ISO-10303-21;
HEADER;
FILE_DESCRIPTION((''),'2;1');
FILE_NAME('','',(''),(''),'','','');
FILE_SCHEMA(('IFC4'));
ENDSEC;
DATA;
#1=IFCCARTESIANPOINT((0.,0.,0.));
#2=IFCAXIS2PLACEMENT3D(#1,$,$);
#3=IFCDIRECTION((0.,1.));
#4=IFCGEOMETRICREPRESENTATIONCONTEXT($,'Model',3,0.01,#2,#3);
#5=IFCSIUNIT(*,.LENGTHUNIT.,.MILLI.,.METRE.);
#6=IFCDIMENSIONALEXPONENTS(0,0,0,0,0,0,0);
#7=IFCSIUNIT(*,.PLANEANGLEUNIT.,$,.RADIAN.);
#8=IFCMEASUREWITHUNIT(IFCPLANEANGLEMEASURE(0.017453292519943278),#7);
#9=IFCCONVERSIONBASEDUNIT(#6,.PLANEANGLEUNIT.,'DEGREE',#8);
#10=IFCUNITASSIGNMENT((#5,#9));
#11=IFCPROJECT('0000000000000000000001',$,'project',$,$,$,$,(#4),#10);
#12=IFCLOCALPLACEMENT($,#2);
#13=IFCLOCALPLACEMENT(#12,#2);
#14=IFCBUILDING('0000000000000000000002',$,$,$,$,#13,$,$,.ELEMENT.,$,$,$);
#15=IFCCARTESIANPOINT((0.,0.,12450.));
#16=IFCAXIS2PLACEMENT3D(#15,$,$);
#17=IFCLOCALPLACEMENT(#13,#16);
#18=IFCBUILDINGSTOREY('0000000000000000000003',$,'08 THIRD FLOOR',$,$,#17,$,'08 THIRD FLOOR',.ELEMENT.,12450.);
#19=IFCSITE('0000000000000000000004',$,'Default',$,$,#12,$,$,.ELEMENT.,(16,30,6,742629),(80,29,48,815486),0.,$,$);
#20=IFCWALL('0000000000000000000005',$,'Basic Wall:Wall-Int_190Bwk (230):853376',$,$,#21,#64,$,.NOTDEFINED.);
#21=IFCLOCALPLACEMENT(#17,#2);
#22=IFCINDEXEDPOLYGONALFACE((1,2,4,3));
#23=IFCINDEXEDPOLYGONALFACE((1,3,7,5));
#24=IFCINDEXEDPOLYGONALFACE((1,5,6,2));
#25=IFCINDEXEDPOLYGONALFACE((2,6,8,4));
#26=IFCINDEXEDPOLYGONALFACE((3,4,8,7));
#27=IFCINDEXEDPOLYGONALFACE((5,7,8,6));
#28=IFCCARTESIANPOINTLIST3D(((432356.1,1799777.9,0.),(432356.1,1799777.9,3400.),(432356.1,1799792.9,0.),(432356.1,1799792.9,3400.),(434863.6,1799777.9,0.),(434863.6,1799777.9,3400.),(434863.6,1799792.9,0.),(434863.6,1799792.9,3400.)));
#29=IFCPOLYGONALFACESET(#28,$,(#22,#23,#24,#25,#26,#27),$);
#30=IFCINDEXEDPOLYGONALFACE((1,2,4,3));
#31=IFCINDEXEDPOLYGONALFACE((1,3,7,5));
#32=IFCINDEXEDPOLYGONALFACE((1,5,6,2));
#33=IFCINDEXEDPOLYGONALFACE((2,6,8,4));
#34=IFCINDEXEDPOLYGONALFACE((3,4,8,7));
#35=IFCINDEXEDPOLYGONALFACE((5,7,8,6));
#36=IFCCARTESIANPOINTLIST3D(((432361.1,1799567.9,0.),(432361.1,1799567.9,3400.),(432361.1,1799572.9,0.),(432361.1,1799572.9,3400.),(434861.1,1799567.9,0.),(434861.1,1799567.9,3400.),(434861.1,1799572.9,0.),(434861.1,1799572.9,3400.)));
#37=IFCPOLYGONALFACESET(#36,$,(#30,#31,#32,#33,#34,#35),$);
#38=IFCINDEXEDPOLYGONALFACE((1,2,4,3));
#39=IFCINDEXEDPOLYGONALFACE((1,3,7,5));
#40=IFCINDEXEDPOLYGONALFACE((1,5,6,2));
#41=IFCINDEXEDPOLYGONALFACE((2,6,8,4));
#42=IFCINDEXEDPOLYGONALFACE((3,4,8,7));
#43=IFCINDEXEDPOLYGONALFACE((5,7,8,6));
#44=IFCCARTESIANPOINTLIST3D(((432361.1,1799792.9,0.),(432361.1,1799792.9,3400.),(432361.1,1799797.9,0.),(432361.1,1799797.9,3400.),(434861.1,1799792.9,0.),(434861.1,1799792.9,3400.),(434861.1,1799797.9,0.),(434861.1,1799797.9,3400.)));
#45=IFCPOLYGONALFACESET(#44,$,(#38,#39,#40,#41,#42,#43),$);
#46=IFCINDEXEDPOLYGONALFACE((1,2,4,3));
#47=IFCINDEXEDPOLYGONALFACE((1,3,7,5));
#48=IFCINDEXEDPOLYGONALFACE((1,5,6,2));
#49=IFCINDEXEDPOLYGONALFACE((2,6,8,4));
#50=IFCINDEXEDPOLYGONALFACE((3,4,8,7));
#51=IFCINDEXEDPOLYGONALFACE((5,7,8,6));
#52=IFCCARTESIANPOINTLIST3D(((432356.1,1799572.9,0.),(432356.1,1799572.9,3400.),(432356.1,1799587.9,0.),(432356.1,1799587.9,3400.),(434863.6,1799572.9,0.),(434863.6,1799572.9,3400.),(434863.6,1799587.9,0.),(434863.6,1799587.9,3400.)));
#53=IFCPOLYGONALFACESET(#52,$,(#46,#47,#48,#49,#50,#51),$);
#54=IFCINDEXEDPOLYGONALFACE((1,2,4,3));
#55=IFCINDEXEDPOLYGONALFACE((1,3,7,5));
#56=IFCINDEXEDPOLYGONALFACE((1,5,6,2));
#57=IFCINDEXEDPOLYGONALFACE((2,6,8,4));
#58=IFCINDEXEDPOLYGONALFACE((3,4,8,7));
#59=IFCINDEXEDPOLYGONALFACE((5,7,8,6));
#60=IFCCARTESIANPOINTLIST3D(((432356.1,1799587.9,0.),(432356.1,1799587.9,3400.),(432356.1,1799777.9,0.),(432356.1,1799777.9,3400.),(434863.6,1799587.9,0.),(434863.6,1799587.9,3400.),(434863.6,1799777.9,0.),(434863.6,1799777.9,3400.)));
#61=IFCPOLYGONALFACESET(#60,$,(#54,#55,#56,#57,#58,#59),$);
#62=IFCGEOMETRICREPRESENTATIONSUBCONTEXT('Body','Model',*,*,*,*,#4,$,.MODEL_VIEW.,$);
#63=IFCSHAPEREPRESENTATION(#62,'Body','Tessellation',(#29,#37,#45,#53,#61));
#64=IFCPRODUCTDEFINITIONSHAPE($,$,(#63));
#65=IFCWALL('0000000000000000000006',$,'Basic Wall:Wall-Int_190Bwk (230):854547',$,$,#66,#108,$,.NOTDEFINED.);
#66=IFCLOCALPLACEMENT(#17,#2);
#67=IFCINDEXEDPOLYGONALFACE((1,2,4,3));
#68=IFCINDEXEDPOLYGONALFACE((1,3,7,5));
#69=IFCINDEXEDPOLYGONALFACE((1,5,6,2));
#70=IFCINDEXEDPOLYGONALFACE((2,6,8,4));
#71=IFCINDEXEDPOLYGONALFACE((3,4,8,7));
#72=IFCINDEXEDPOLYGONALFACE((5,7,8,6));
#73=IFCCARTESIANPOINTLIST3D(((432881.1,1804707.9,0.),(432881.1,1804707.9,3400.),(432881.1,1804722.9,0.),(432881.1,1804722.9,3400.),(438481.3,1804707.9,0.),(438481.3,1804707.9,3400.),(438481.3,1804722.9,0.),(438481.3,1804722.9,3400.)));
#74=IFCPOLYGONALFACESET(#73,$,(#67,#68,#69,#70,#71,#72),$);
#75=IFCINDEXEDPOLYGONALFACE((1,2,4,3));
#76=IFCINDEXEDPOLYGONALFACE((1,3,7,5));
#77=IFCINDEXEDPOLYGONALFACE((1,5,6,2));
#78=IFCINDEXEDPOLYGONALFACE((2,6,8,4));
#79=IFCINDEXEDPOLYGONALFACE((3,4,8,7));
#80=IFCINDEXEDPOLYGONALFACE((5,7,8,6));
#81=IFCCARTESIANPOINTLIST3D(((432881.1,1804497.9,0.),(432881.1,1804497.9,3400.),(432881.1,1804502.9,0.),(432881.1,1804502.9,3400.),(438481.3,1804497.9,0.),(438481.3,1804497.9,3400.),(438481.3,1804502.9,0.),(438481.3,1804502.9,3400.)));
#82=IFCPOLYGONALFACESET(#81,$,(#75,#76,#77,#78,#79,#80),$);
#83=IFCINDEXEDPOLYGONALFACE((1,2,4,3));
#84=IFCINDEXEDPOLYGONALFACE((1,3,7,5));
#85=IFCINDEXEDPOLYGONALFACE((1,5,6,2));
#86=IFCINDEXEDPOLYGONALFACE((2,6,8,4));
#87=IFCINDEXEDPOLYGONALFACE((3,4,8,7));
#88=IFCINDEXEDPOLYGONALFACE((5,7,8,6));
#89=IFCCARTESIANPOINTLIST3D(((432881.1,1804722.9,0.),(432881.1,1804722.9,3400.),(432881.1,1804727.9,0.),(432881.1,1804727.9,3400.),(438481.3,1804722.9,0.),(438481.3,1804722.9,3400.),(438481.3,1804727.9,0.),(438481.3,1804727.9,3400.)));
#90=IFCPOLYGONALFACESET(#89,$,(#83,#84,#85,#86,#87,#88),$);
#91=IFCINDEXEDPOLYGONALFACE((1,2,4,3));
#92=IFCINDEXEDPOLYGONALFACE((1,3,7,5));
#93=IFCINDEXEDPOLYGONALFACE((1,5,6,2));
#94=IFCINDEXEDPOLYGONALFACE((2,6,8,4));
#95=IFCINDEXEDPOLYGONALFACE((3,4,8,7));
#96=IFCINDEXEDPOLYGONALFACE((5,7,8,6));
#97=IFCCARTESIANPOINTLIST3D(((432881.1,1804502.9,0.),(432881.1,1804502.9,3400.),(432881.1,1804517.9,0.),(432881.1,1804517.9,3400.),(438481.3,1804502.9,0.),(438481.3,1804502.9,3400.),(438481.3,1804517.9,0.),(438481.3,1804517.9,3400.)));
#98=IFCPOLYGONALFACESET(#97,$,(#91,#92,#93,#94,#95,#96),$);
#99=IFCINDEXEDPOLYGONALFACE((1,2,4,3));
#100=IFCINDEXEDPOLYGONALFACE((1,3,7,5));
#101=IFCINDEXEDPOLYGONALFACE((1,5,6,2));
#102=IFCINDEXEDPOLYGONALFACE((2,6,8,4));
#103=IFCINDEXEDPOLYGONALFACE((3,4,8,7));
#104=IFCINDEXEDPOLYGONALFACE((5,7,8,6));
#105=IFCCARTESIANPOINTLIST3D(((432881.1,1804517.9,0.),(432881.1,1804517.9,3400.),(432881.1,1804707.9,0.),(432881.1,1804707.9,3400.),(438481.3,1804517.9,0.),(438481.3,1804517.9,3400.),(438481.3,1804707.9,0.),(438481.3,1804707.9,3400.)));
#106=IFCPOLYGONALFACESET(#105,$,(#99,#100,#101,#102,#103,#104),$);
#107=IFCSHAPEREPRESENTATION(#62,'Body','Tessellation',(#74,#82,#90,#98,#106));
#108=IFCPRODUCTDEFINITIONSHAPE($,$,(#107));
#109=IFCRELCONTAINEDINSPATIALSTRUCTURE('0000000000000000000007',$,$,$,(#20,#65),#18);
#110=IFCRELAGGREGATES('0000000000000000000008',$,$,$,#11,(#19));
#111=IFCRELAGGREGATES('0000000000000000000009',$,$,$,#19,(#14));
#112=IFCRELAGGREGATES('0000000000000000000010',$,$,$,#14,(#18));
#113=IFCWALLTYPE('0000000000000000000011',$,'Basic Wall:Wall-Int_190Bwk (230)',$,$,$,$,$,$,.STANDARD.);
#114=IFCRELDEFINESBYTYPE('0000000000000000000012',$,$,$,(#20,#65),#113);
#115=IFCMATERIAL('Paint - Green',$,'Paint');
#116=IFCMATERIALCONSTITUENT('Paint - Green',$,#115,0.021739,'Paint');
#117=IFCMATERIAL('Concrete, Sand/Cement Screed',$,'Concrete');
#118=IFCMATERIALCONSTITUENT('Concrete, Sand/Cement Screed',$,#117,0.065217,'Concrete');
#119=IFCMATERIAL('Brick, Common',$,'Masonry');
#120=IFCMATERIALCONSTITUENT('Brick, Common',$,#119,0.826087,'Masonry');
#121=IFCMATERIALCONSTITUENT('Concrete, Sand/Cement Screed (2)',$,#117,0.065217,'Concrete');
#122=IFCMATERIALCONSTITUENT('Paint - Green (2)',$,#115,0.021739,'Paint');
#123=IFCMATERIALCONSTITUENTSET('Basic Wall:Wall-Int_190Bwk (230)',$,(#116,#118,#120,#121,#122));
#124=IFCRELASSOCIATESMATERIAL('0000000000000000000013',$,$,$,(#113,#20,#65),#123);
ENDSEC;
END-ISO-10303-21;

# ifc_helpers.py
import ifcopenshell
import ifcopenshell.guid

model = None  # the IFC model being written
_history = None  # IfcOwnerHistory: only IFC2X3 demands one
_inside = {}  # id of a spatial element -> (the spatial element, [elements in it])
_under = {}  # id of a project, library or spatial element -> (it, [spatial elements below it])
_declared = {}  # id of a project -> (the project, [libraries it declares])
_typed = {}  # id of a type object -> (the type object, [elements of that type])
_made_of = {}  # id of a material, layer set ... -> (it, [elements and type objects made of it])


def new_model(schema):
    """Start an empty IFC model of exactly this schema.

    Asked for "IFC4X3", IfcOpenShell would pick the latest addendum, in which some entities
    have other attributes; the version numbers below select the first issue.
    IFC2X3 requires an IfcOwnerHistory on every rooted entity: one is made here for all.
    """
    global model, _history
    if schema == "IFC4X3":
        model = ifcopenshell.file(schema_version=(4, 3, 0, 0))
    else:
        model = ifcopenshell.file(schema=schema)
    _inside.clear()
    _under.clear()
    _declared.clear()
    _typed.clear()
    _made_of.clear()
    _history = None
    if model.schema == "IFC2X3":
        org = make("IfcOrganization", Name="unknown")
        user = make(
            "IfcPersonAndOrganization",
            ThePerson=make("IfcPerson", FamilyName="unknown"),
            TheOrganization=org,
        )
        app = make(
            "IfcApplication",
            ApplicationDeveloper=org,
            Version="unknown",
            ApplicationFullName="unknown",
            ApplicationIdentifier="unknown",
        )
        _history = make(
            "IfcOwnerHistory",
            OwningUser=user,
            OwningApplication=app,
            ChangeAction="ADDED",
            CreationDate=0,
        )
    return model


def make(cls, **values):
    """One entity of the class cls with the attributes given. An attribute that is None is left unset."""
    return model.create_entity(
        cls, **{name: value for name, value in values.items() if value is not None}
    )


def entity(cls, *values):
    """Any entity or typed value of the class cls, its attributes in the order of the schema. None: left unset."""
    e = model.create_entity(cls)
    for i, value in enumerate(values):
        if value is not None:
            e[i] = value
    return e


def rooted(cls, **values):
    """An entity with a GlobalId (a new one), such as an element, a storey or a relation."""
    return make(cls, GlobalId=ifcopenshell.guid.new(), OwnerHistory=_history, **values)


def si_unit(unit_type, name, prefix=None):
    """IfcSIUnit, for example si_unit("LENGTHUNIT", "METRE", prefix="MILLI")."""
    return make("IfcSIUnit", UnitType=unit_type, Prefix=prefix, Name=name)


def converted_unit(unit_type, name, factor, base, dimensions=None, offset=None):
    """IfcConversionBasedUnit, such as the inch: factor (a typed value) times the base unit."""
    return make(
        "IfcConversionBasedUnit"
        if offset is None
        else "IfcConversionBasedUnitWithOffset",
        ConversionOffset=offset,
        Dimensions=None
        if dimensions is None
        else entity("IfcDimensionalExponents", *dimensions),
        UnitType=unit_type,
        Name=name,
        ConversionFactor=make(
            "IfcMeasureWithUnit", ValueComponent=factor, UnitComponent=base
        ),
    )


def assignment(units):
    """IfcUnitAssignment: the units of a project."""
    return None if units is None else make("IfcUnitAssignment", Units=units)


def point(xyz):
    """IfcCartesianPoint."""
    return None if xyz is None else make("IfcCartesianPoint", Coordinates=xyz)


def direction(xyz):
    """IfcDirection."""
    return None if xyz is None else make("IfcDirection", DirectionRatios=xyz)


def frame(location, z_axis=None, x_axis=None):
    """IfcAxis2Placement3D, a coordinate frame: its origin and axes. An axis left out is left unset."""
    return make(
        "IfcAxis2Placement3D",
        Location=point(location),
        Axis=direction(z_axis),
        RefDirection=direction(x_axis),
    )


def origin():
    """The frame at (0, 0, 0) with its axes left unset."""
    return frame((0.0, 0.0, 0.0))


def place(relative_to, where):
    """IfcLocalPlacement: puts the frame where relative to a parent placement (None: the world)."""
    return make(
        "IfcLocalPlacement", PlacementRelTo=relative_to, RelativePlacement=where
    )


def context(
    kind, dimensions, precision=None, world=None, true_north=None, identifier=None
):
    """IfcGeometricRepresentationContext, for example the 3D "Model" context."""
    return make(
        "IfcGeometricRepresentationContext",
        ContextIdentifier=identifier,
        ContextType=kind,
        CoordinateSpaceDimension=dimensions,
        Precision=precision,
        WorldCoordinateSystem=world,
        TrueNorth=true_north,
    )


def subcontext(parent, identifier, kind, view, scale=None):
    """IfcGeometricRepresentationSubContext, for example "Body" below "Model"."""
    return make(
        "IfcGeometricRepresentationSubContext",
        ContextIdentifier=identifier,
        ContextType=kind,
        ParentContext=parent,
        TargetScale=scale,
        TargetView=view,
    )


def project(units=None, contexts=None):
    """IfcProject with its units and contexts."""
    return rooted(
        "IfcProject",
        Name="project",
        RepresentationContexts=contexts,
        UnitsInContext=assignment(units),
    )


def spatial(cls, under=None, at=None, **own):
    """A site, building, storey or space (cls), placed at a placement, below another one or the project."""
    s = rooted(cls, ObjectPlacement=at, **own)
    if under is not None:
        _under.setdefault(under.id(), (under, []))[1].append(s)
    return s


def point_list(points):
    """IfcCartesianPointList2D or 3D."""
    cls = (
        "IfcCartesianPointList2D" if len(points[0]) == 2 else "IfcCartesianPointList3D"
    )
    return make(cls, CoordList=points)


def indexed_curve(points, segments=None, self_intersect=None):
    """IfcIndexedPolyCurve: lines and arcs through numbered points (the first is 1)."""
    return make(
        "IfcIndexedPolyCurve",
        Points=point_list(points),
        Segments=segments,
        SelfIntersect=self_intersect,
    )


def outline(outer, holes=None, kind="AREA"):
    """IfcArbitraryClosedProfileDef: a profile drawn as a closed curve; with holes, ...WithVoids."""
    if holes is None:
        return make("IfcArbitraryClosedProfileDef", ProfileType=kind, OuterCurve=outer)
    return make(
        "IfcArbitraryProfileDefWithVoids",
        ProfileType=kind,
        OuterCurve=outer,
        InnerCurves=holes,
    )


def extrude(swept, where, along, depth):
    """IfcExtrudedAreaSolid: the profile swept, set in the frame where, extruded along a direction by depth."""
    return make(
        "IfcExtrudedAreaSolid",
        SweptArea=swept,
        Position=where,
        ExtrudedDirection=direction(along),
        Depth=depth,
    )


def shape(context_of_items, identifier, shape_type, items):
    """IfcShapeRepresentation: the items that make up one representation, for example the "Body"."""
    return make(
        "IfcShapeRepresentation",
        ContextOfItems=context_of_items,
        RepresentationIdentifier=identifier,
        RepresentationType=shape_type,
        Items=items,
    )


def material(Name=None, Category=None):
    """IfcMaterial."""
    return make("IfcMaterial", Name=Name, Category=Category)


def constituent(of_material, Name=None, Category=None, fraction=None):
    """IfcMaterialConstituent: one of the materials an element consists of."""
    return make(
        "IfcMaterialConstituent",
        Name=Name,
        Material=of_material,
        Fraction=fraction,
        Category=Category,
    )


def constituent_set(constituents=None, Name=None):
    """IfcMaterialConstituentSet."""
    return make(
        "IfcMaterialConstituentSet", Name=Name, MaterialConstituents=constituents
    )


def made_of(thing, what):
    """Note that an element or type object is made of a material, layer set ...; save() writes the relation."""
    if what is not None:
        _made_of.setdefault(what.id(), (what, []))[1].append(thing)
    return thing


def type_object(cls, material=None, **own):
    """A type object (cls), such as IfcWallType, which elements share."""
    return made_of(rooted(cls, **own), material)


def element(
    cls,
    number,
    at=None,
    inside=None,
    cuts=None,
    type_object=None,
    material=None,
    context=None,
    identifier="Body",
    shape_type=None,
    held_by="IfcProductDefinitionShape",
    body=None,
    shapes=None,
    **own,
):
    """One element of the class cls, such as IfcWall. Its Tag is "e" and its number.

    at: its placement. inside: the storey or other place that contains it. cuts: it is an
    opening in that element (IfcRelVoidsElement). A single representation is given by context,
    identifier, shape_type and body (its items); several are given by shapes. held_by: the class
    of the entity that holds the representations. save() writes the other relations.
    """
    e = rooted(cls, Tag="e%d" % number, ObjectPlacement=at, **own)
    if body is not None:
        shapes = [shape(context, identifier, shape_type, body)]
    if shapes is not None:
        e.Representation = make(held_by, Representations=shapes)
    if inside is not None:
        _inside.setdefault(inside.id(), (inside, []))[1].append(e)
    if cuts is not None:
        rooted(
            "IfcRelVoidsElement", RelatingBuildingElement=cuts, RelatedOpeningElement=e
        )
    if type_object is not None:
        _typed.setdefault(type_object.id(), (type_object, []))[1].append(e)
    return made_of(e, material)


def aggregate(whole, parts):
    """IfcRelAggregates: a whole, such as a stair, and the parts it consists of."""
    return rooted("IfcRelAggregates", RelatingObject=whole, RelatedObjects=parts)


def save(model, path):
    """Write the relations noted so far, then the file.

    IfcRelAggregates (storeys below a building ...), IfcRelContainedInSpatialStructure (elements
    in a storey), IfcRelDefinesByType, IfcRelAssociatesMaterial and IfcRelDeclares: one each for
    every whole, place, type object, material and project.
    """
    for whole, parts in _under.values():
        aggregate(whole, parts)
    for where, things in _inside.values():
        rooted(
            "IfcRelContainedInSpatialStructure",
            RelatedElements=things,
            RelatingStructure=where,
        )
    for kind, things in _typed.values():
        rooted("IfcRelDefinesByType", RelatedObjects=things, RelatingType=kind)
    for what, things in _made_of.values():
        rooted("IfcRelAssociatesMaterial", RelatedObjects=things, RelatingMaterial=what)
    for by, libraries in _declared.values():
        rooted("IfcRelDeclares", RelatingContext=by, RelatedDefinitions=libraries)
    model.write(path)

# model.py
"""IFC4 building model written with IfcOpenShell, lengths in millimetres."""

from ifc_helpers import new_model, entity, si_unit, converted_unit, direction, frame, origin, place, context, subcontext, project, spatial, indexed_curve, outline, extrude, material, constituent, constituent_set, type_object, element, save


model = new_model("IFC4")

# Units and contexts
model_context = context("Model", 3, precision=0.01, world=origin(), true_north=direction((0.0, 1.0)))
body_context = subcontext(model_context, "Body", "Model", "MODEL_VIEW")
ifc_project = project(units=[si_unit("LENGTHUNIT", "METRE", prefix="MILLI"), converted_unit("PLANEANGLEUNIT", "DEGREE", entity("IfcPlaneAngleMeasure", 0.017453292519943278), si_unit("PLANEANGLEUNIT", "RADIAN"), dimensions=[0, 0, 0, 0, 0, 0, 0])], contexts=[model_context])

# Site, building, storey
site_placement = place(None, origin())
site = spatial("IfcSite", under=ifc_project, at=site_placement, Name="Default", CompositionType="ELEMENT", RefLatitude=(16, 30, 6, 742629), RefLongitude=(80, 29, 48, 815486), RefElevation=0.0)
building_placement = place(site_placement, origin())
building = spatial("IfcBuilding", under=site, at=building_placement, CompositionType="ELEMENT")
storey_placement = place(building_placement, frame((0.0, 0.0, 12450.0)))
storey = spatial("IfcBuildingStorey", under=building, at=storey_placement, Name="08 THIRD FLOOR", LongName="08 THIRD FLOOR", CompositionType="ELEMENT", Elevation=12450.0)

# Shared definitions
ifc_material_1 = material(Name="Concrete, Sand/Cement Screed", Category="Concrete")
ifc_material_2 = material(Name="Brick, Common", Category="Masonry")

# Wall
ifc_material_3 = material(Name="Paint - Green", Category="Paint")
ifc_constituent_1 = constituent(ifc_material_3, Name="Paint - Green", Category="Paint", fraction=0.021739)
ifc_constituent_2 = constituent(ifc_material_1, Name="Concrete, Sand/Cement Screed", Category="Concrete", fraction=0.065217)
ifc_constituent_3 = constituent(ifc_material_2, Name="Brick, Common", Category="Masonry", fraction=0.826087)
ifc_constituent_4 = constituent(ifc_material_1, Name="Concrete, Sand/Cement Screed (2)", Category="Concrete", fraction=0.065217)
ifc_constituent_5 = constituent(ifc_material_3, Name="Paint - Green (2)", Category="Paint", fraction=0.021739)
ifc_constituent_set_1 = constituent_set(constituents=[ifc_constituent_1, ifc_constituent_2, ifc_constituent_3, ifc_constituent_4, ifc_constituent_5], Name="Basic Wall:Wall-Int_190Bwk (230)")
wall_type_1 = type_object("IfcWallType", Name="Basic Wall:Wall-Int_190Bwk (230)", PredefinedType="STANDARD", material=ifc_constituent_set_1)
wall_1_placement = place(storey_placement, frame((432361.1, 1799682.9, 0.0)))
element("IfcWall", 1, at=wall_1_placement, inside=storey, type_object=wall_type_1, material=ifc_constituent_set_1, Name="Basic Wall:Wall-Int_190Bwk (230):853376", PredefinedType="NOTDEFINED", context=body_context, shape_type="SweptSolid", body=[
    extrude(outline(indexed_curve([(-1253.7, -7.5), (1253.7, -7.5), (1253.7, 7.5), (-1253.7, 7.5), (-1253.7, -7.5)], self_intersect=False)), frame((1248.7, 102.5, 0.0)), (0.0, 0.0, 1.0), 3400.0),
    extrude(outline(indexed_curve([(-2.5, -1250.0), (2.5, -1250.0), (2.5, 1250.0), (-2.5, 1250.0), (-2.5, -1250.0)], self_intersect=False)), frame((1250.0, -112.5, 0.0), z_axis=(0.0, 0.0, 1.0), x_axis=(0.0, 1.0, 0.0)), (0.0, 0.0, 1.0), 3400.0),
    extrude(outline(indexed_curve([(-2.5, -1250.0), (2.5, -1250.0), (2.5, 1250.0), (-2.5, 1250.0), (-2.5, -1250.0)], self_intersect=False)), frame((1250.0, 112.5, 0.0), z_axis=(0.0, 0.0, 1.0), x_axis=(0.0, -1.0, 0.0)), (0.0, 0.0, 1.0), 3400.0),
    extrude(outline(indexed_curve([(-1253.7, -7.5), (1253.7, -7.5), (1253.7, 7.5), (-1253.7, 7.5), (-1253.7, -7.5)], self_intersect=False)), frame((1248.7, -102.5, 0.0)), (0.0, 0.0, 1.0), 3400.0),
    extrude(outline(indexed_curve([(-1253.7, -95.0), (1253.7, -95.0), (1253.7, 95.0), (-1253.7, 95.0), (-1253.7, -95.0)], self_intersect=False)), frame((1248.7, 0.0, 0.0)), (0.0, 0.0, 1.0), 3400.0),
])

# Wall
wall_2_placement = place(storey_placement, frame((432881.1, 1804612.9, 0.0)))
element("IfcWall", 2, at=wall_2_placement, inside=storey, type_object=wall_type_1, material=ifc_constituent_set_1, Name="Basic Wall:Wall-Int_190Bwk (230):854547", PredefinedType="NOTDEFINED", context=body_context, shape_type="SweptSolid", body=[
    extrude(outline(indexed_curve([(-2800.1, -7.5), (2800.1, -7.5), (2800.1, 7.5), (-2800.1, 7.5), (-2800.1, -7.5)], self_intersect=False)), frame((2800.1, 102.5, 0.0)), (0.0, 0.0, 1.0), 3400.0),
    extrude(outline(indexed_curve([(-2.5, -2800.1), (2.5, -2800.1), (2.5, 2800.1), (-2.5, 2800.1), (-2.5, -2800.1)], self_intersect=False)), frame((2800.1, -112.5, 0.0), z_axis=(0.0, 0.0, 1.0), x_axis=(0.0, 1.0, 0.0)), (0.0, 0.0, 1.0), 3400.0),
    extrude(outline(indexed_curve([(-2.5, -2800.1), (2.5, -2800.1), (2.5, 2800.1), (-2.5, 2800.1), (-2.5, -2800.1)], self_intersect=False)), frame((2800.1, 112.5, 0.0), z_axis=(0.0, 0.0, 1.0), x_axis=(0.0, -1.0, 0.0)), (0.0, 0.0, 1.0), 3400.0),
    extrude(outline(indexed_curve([(-2800.1, -7.5), (2800.1, -7.5), (2800.1, 7.5), (-2800.1, 7.5), (-2800.1, -7.5)], self_intersect=False)), frame((2800.1, -102.5, 0.0)), (0.0, 0.0, 1.0), 3400.0),
    extrude(outline(indexed_curve([(-2800.1, -95.0), (2800.1, -95.0), (2800.1, 95.0), (-2800.1, 95.0), (-2800.1, -95.0)], self_intersect=False)), frame((2800.1, 0.0, 0.0)), (0.0, 0.0, 1.0), 3400.0),
])

save(model, "model.ifc")
